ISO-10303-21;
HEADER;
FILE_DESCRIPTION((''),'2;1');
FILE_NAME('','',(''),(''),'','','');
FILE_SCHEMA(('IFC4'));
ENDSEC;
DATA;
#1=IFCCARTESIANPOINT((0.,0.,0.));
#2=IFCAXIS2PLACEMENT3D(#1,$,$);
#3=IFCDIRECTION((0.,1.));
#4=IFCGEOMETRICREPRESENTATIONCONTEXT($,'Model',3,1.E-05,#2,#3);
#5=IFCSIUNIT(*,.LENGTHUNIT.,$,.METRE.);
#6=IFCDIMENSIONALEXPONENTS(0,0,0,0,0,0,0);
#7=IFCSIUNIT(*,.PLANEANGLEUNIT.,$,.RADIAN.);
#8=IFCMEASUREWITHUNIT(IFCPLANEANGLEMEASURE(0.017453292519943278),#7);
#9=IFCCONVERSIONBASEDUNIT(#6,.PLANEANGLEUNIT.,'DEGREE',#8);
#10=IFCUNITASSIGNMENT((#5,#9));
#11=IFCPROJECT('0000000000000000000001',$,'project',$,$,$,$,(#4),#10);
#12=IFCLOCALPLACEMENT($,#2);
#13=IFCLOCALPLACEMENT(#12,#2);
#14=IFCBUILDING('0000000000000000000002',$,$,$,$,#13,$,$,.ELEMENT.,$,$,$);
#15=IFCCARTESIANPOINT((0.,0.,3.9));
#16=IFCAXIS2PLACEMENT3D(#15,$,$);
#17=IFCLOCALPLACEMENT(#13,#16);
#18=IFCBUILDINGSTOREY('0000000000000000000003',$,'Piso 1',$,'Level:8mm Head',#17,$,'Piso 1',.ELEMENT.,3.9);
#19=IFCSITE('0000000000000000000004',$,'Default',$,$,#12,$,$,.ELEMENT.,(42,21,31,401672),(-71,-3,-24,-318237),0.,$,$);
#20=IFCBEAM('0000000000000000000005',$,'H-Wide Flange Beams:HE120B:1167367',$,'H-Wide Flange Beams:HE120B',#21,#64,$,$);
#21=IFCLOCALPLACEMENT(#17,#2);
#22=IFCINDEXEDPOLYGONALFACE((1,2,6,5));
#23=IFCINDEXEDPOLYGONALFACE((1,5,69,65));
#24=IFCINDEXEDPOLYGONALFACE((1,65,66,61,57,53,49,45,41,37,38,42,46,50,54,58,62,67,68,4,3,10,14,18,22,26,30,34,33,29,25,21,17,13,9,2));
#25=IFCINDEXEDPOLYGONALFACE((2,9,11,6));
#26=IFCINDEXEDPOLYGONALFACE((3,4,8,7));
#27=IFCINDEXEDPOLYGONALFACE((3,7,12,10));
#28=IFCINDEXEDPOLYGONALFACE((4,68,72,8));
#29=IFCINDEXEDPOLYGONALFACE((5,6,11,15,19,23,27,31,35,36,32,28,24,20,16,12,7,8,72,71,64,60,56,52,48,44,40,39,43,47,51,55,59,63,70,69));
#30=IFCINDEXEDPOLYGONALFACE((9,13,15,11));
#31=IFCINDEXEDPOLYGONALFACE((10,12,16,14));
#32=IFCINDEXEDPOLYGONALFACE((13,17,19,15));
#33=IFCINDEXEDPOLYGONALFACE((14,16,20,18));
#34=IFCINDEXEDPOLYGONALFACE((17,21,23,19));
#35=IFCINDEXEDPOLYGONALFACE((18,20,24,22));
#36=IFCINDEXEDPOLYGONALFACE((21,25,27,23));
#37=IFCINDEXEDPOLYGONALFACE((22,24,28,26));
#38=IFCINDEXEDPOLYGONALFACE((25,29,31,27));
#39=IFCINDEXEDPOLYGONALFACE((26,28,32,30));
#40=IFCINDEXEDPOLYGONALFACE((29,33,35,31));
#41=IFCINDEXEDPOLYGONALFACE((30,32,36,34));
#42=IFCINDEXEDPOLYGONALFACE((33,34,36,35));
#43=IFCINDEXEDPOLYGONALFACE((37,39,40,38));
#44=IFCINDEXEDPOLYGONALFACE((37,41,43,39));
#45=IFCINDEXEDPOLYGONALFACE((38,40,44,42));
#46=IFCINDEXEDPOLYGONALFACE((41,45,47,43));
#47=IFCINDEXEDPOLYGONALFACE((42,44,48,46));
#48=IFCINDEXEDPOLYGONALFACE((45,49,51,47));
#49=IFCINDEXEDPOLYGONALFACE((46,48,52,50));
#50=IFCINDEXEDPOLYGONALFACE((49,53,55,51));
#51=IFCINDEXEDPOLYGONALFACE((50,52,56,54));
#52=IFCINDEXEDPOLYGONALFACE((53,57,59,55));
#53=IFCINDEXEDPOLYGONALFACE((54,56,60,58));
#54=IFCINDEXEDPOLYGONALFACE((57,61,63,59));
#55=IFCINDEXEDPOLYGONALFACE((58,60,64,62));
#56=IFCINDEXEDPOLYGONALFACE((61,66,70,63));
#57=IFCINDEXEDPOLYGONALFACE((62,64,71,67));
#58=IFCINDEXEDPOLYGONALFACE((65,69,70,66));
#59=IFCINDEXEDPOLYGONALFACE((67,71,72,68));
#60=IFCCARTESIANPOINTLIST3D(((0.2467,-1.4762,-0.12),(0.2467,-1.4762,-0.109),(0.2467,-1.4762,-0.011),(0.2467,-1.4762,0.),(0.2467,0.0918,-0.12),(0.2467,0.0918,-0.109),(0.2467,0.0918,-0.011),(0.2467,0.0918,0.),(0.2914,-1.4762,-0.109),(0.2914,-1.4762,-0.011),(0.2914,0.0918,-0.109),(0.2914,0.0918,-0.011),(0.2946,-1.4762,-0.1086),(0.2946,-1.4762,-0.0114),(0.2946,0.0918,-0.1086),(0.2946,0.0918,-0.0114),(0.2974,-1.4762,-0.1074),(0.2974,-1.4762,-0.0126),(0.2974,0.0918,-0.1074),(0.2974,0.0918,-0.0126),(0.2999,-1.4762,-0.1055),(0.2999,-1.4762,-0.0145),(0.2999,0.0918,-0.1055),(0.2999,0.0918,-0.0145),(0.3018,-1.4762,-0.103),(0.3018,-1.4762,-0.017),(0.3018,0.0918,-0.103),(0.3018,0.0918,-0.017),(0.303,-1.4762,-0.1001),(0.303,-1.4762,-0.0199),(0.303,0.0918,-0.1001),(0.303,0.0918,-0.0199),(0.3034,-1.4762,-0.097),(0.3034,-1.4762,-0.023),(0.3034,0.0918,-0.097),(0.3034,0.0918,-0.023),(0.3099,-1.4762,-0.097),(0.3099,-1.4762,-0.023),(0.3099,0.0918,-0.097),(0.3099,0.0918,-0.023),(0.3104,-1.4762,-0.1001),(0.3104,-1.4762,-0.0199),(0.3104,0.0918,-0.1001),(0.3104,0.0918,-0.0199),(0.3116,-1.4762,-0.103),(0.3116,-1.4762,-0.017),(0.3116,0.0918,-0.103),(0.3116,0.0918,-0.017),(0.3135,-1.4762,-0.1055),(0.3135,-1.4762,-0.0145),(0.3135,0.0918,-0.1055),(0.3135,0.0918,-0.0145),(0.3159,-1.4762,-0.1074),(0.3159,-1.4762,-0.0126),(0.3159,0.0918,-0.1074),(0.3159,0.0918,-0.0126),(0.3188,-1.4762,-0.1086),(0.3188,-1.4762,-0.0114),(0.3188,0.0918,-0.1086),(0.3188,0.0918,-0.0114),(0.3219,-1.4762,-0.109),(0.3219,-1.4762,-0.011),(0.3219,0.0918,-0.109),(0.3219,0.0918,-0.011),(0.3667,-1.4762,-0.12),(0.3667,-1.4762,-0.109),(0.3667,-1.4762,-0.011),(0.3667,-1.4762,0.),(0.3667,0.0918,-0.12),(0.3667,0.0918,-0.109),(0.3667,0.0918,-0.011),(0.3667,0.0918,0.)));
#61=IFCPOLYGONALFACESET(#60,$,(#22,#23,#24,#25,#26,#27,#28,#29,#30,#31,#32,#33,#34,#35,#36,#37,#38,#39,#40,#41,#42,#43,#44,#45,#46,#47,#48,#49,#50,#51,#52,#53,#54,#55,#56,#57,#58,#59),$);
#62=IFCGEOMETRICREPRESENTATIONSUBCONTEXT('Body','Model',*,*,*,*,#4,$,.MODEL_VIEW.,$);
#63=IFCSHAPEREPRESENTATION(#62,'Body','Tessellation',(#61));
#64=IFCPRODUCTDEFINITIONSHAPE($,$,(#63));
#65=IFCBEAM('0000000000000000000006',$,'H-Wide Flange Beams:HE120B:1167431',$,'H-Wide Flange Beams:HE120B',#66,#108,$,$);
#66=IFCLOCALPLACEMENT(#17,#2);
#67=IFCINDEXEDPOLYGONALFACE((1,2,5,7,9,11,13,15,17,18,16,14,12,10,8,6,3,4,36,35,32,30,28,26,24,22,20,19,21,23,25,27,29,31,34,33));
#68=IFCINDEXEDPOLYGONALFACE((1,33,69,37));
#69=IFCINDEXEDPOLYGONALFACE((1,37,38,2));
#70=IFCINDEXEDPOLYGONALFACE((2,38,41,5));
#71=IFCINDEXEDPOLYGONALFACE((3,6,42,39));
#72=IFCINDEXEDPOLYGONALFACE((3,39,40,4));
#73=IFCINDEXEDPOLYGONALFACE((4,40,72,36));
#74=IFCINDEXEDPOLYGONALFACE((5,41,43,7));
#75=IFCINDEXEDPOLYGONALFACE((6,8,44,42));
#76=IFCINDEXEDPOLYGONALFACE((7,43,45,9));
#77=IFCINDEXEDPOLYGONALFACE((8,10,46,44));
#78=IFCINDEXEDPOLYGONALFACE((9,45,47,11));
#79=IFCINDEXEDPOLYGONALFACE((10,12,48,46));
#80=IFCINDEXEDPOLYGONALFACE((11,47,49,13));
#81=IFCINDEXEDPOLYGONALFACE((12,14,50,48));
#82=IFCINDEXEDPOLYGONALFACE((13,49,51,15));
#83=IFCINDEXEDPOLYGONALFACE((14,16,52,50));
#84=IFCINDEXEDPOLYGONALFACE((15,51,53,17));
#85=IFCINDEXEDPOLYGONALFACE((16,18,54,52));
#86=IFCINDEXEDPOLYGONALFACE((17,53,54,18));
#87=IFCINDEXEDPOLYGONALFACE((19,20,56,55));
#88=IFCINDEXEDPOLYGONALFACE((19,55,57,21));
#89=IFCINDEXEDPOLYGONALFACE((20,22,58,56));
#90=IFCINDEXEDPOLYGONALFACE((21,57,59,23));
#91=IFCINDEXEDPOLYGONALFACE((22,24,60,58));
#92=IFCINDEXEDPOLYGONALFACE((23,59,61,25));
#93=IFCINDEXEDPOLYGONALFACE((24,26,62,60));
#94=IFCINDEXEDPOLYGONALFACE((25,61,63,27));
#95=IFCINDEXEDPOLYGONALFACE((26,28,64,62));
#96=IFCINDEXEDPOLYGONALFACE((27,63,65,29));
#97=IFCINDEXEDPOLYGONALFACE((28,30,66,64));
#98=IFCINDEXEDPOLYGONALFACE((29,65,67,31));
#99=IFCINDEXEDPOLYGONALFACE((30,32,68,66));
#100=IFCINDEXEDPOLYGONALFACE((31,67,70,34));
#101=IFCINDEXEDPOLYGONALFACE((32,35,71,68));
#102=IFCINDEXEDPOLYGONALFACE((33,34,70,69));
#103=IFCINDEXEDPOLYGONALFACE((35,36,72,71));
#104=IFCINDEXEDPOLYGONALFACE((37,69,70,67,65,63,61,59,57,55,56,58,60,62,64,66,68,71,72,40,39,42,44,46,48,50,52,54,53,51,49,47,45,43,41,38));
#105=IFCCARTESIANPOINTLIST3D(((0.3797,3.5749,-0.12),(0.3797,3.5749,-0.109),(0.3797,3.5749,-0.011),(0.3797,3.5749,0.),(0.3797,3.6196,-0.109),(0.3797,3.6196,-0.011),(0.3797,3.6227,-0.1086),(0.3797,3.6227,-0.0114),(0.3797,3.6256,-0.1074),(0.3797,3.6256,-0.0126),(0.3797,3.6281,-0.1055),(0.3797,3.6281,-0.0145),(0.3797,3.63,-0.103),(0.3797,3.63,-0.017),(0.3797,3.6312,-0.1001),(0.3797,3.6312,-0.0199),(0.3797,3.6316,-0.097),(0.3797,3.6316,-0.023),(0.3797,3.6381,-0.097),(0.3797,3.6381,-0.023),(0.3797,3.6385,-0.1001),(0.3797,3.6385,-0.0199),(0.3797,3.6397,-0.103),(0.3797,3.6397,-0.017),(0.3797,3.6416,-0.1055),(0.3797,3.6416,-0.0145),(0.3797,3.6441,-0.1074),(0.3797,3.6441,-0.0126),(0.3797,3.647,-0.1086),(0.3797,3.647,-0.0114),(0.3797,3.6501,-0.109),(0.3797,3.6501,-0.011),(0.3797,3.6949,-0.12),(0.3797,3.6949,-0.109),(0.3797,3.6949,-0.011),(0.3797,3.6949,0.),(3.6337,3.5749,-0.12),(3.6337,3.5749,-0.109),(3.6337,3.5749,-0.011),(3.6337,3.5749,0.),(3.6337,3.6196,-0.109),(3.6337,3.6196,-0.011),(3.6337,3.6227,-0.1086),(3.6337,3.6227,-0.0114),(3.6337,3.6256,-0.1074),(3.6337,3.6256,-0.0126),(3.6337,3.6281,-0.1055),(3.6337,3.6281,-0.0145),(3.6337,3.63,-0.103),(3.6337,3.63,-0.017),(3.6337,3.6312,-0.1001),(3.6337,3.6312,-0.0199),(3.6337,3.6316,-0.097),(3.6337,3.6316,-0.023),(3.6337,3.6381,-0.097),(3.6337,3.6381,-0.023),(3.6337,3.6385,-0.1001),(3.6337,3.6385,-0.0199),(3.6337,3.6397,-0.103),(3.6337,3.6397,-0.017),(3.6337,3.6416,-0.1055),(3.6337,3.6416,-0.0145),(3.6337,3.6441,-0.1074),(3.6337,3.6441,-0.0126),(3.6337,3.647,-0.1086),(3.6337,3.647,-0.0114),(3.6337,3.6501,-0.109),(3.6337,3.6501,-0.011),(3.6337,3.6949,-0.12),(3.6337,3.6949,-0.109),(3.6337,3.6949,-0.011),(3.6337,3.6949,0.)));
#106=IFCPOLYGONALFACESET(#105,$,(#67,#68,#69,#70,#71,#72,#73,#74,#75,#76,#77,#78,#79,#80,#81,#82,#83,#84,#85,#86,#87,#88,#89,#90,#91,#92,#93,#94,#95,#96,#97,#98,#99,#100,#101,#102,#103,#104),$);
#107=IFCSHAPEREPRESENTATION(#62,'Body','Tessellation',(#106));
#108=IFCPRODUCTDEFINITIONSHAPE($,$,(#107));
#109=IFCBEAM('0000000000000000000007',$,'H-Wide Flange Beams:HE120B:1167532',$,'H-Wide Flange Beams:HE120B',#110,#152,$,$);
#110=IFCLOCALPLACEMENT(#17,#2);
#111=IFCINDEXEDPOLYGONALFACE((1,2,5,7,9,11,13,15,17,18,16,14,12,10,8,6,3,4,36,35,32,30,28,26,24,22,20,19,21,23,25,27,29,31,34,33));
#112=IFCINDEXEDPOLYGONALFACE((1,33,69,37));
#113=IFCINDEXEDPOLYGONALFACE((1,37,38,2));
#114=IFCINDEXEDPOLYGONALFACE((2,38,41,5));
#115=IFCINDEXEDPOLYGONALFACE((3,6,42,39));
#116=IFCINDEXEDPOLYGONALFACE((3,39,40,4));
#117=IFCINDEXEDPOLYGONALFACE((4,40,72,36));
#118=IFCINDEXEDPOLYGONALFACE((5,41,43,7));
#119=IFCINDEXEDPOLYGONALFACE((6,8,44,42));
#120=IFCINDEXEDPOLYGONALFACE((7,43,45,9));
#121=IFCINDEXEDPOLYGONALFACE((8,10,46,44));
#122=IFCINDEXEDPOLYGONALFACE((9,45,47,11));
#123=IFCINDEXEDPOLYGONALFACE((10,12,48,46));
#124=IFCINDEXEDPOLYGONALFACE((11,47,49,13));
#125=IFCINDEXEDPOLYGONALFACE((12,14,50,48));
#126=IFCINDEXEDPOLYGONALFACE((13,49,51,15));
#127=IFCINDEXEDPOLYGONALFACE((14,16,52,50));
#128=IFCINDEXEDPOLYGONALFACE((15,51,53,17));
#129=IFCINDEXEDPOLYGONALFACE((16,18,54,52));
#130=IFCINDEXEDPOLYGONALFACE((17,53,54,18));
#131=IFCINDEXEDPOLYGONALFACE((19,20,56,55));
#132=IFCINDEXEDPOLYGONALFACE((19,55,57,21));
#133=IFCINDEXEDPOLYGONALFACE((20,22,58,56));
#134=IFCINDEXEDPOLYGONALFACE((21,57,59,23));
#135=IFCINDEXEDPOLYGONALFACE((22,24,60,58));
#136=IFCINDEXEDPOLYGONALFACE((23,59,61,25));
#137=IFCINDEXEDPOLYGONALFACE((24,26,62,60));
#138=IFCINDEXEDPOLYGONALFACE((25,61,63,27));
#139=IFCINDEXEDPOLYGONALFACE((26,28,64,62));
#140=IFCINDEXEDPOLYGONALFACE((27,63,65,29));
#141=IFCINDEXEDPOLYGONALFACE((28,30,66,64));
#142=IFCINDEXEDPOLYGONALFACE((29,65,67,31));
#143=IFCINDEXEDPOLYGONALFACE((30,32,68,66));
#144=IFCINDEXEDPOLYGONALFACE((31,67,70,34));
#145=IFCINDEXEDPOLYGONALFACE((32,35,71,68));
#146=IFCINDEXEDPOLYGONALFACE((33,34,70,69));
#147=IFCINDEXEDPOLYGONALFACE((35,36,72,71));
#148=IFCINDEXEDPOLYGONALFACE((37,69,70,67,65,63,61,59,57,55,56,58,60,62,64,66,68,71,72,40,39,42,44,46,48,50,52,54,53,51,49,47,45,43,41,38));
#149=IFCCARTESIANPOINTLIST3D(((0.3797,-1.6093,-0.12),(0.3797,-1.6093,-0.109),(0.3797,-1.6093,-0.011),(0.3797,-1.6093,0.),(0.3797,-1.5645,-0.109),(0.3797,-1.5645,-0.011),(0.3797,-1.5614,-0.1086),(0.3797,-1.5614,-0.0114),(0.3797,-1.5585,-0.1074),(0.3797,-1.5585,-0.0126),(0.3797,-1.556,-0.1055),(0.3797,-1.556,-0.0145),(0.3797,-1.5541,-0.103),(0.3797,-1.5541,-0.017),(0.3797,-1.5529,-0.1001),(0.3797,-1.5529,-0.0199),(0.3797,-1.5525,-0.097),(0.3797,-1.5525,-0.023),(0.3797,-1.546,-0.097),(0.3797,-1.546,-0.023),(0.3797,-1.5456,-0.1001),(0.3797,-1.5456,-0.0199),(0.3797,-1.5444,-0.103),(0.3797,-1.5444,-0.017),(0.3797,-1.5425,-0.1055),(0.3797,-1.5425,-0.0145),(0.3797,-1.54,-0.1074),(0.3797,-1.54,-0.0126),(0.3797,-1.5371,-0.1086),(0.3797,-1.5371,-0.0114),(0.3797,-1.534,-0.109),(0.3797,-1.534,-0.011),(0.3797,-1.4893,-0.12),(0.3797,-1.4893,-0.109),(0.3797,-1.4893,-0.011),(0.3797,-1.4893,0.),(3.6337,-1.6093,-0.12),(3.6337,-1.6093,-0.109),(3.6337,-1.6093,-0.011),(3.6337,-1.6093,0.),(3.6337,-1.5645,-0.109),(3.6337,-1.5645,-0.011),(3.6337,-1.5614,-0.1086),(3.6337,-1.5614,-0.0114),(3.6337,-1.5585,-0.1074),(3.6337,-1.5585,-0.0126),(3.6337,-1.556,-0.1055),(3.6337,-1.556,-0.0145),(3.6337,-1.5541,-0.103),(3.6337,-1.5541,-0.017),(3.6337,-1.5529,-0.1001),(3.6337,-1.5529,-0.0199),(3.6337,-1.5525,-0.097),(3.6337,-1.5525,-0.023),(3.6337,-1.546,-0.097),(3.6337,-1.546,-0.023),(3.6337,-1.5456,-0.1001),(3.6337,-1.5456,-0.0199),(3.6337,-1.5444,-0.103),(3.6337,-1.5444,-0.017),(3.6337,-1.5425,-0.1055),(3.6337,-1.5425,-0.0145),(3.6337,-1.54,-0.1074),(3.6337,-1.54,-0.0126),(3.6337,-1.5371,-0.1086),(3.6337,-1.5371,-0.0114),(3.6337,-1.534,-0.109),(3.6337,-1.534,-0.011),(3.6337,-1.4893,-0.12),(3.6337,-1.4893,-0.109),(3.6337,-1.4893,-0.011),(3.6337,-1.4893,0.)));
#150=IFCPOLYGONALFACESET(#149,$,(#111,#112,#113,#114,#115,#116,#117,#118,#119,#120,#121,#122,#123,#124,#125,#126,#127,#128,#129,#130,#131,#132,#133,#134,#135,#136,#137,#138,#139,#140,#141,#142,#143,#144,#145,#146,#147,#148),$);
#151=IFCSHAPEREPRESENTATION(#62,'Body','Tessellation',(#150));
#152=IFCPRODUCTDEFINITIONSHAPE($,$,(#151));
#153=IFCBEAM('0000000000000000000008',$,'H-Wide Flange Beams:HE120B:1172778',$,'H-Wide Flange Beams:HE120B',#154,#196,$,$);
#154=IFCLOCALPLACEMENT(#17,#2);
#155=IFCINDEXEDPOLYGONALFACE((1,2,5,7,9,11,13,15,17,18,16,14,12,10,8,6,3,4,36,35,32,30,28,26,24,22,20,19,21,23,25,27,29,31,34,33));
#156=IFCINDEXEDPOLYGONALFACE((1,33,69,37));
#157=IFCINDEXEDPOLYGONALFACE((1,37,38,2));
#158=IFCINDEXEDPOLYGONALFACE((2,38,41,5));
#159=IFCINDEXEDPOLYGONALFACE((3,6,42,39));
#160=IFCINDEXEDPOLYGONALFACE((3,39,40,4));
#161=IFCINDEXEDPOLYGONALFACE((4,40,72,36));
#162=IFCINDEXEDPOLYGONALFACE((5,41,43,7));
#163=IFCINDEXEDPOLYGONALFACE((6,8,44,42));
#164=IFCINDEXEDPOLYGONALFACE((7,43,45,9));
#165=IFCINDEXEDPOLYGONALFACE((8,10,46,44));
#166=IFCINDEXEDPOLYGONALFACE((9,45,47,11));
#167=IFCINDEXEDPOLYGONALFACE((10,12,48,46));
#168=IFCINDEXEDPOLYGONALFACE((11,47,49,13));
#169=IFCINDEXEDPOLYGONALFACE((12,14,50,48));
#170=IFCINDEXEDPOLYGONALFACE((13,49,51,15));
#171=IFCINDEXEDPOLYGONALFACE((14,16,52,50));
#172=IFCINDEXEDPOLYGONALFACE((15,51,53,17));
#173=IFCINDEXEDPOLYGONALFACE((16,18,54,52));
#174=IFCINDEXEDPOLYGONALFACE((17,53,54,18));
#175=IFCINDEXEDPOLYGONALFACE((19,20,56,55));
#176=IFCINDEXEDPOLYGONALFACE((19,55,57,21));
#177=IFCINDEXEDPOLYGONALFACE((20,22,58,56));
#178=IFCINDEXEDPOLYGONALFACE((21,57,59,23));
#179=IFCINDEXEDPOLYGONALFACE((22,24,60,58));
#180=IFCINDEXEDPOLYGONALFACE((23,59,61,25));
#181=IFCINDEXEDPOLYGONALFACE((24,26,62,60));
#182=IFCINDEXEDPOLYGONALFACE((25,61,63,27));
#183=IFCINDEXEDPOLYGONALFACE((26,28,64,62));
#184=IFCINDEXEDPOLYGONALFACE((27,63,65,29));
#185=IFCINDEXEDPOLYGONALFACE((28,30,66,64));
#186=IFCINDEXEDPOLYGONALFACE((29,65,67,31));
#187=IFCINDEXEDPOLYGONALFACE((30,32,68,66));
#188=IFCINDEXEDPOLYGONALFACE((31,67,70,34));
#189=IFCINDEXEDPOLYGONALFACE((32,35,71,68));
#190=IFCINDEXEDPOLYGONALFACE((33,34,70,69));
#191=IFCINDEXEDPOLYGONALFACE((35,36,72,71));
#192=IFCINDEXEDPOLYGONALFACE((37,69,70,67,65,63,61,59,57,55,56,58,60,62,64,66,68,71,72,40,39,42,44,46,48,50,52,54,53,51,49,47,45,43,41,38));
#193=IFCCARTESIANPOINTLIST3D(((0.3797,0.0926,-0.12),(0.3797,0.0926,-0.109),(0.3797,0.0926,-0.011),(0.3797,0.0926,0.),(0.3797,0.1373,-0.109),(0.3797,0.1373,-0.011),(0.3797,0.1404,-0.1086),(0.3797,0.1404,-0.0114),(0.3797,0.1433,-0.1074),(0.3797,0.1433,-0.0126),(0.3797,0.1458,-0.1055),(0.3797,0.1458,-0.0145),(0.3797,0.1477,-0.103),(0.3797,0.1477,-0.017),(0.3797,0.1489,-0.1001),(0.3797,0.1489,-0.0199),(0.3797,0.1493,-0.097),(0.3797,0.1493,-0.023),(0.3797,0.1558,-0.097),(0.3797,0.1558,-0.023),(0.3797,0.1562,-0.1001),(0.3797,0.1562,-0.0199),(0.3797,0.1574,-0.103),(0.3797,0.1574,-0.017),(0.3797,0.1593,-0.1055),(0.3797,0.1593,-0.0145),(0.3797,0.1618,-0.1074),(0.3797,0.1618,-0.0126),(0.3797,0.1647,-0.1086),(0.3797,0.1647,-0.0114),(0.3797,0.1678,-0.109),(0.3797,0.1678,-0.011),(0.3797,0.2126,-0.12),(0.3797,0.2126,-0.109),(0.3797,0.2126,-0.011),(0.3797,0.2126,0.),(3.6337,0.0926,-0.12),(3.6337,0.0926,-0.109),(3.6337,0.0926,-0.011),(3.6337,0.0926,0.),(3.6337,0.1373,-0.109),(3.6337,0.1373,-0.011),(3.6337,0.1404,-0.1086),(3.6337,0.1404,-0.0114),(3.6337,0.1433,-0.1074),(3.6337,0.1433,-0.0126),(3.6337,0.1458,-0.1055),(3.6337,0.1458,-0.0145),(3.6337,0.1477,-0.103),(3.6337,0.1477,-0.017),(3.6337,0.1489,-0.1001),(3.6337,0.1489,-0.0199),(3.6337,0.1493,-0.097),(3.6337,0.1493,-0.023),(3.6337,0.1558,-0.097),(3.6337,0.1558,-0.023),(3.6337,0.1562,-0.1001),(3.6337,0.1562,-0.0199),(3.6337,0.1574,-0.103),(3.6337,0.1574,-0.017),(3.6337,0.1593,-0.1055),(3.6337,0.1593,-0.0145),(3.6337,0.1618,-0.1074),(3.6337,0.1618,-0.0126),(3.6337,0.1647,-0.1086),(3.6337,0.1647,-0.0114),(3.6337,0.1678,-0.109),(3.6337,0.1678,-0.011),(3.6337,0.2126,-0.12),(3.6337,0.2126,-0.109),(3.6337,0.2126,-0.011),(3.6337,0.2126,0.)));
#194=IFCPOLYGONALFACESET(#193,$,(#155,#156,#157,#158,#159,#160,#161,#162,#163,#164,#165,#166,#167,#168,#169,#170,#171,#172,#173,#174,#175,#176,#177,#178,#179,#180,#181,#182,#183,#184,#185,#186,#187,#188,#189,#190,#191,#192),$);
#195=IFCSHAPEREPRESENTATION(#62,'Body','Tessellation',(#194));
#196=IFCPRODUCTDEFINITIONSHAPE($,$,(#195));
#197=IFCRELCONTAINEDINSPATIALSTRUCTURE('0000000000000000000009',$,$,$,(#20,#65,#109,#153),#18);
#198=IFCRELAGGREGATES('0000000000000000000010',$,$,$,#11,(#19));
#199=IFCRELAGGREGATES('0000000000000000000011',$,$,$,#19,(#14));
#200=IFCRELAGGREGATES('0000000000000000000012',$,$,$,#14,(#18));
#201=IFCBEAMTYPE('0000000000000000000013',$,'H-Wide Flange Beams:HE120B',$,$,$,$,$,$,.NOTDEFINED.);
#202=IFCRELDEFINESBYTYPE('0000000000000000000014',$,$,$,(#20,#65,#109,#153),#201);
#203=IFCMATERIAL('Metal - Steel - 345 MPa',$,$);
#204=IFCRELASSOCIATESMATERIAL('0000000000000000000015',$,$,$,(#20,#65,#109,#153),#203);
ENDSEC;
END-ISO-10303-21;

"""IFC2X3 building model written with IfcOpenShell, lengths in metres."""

from ifc_helpers import new_model, entity, si_unit, converted_unit, direction, frame, frame_2d, origin, place, context, subcontext, project, spatial, i_section, extrude, material, type_object, element, save


model = new_model("IFC2X3")

# Units and contexts
model_context = context("Model", 3, precision=1e-05, world=origin(), true_north=direction((0.0, 1.0)))
body_context = subcontext(model_context, "Body", "Model", "MODEL_VIEW")
ifc_project = project(units=[si_unit("LENGTHUNIT", "METRE"), converted_unit("PLANEANGLEUNIT", "DEGREE", entity("IfcPlaneAngleMeasure", 0.017453292519943278), si_unit("PLANEANGLEUNIT", "RADIAN"), dimensions=[0, 0, 0, 0, 0, 0, 0])], contexts=[model_context])

# Site, building, storey
site_placement = place(None, origin())
site = spatial("IfcSite", under=ifc_project, at=site_placement, Name="Default", CompositionType="ELEMENT", RefLatitude=(42, 21, 31, 401672), RefLongitude=(-71, -3, -24, -318237), RefElevation=0.0)
building_placement = place(site_placement, origin())
building = spatial("IfcBuilding", under=site, at=building_placement, CompositionType="ELEMENT")
storey_placement = place(building_placement, frame((0.0, 0.0, 3.9)))
storey = spatial("IfcBuildingStorey", under=building, at=storey_placement, Name="Piso 1", ObjectType="Level:8mm Head", LongName="Piso 1", CompositionType="ELEMENT", Elevation=3.9)

# Beams
ifc_material_1 = material(Name="Metal - Steel - 345 MPa")
beam_type_1 = type_object("IfcBeamType", Name="H-Wide Flange Beams:HE120B", PredefinedType="NOTDEFINED")
beam_1_placement = place(storey_placement, frame((0.3067, -1.5493, 0.0), z_axis=(0.0, 0.0, 1.0), x_axis=(0.0, 1.0, 0.0)))
element("IfcBeam", 1, at=beam_1_placement, inside=storey, type_object=beam_type_1, material=ifc_material_1, Name="H-Wide Flange Beams:HE120B:1167367", ObjectType="H-Wide Flange Beams:HE120B", context=body_context, shape_type="SweptSolid", body=[
    extrude(i_section(OverallWidth=0.12, OverallDepth=0.12, WebThickness=0.0065, FlangeThickness=0.011, FilletRadius=0.012, at=frame_2d((0.0, 0.0), x_axis=(0.0, 1.0))), frame((0.073, 0.0, -0.06), z_axis=(1.0, 0.0, 0.0), x_axis=(0.0, 0.0, -1.0)), (0.0, 0.0, 1.0), 1.568),
])
beam_2_placement = place(storey_placement, frame((0.3067, 3.6349, 0.0)))
element("IfcBeam", 2, at=beam_2_placement, inside=storey, type_object=beam_type_1, material=ifc_material_1, Name="H-Wide Flange Beams:HE120B:1167431", ObjectType="H-Wide Flange Beams:HE120B", context=body_context, shape_type="SweptSolid", body=[
    extrude(i_section(OverallWidth=0.12, OverallDepth=0.12, WebThickness=0.0065, FlangeThickness=0.011, FilletRadius=0.012, at=frame_2d((0.0, 0.0), x_axis=(0.0, 1.0))), frame((0.073, 0.0, -0.06), z_axis=(1.0, 0.0, 0.0), x_axis=(0.0, 0.0, -1.0)), (0.0, 0.0, 1.0), 3.254),
])
beam_3_placement = place(storey_placement, frame((3.7067, -1.5493, 0.0), z_axis=(0.0, 0.0, 1.0), x_axis=(-1.0, 0.0, 0.0)))
element("IfcBeam", 3, at=beam_3_placement, inside=storey, type_object=beam_type_1, material=ifc_material_1, Name="H-Wide Flange Beams:HE120B:1167532", ObjectType="H-Wide Flange Beams:HE120B", context=body_context, shape_type="SweptSolid", body=[
    extrude(i_section(OverallWidth=0.12, OverallDepth=0.12, WebThickness=0.0065, FlangeThickness=0.011, FilletRadius=0.012, at=frame_2d((0.0, 0.0), x_axis=(0.0, 1.0))), frame((0.073, 0.0, -0.06), z_axis=(1.0, 0.0, 0.0), x_axis=(0.0, 0.0, -1.0)), (0.0, 0.0, 1.0), 3.254),
])
beam_4_placement = place(storey_placement, frame((0.3067, 0.1526, 0.0)))
element("IfcBeam", 4, at=beam_4_placement, inside=storey, type_object=beam_type_1, material=ifc_material_1, Name="H-Wide Flange Beams:HE120B:1172778", ObjectType="H-Wide Flange Beams:HE120B", context=body_context, shape_type="SweptSolid", body=[
    extrude(i_section(OverallWidth=0.12, OverallDepth=0.12, WebThickness=0.0065, FlangeThickness=0.011, FilletRadius=0.012, at=frame_2d((0.0, 0.0), x_axis=(0.0, 1.0))), frame((0.073, 0.0, -0.06), z_axis=(1.0, 0.0, 0.0), x_axis=(0.0, 0.0, -1.0)), (0.0, 0.0, 1.0), 3.254),
])

save(model, "model.ifc")
